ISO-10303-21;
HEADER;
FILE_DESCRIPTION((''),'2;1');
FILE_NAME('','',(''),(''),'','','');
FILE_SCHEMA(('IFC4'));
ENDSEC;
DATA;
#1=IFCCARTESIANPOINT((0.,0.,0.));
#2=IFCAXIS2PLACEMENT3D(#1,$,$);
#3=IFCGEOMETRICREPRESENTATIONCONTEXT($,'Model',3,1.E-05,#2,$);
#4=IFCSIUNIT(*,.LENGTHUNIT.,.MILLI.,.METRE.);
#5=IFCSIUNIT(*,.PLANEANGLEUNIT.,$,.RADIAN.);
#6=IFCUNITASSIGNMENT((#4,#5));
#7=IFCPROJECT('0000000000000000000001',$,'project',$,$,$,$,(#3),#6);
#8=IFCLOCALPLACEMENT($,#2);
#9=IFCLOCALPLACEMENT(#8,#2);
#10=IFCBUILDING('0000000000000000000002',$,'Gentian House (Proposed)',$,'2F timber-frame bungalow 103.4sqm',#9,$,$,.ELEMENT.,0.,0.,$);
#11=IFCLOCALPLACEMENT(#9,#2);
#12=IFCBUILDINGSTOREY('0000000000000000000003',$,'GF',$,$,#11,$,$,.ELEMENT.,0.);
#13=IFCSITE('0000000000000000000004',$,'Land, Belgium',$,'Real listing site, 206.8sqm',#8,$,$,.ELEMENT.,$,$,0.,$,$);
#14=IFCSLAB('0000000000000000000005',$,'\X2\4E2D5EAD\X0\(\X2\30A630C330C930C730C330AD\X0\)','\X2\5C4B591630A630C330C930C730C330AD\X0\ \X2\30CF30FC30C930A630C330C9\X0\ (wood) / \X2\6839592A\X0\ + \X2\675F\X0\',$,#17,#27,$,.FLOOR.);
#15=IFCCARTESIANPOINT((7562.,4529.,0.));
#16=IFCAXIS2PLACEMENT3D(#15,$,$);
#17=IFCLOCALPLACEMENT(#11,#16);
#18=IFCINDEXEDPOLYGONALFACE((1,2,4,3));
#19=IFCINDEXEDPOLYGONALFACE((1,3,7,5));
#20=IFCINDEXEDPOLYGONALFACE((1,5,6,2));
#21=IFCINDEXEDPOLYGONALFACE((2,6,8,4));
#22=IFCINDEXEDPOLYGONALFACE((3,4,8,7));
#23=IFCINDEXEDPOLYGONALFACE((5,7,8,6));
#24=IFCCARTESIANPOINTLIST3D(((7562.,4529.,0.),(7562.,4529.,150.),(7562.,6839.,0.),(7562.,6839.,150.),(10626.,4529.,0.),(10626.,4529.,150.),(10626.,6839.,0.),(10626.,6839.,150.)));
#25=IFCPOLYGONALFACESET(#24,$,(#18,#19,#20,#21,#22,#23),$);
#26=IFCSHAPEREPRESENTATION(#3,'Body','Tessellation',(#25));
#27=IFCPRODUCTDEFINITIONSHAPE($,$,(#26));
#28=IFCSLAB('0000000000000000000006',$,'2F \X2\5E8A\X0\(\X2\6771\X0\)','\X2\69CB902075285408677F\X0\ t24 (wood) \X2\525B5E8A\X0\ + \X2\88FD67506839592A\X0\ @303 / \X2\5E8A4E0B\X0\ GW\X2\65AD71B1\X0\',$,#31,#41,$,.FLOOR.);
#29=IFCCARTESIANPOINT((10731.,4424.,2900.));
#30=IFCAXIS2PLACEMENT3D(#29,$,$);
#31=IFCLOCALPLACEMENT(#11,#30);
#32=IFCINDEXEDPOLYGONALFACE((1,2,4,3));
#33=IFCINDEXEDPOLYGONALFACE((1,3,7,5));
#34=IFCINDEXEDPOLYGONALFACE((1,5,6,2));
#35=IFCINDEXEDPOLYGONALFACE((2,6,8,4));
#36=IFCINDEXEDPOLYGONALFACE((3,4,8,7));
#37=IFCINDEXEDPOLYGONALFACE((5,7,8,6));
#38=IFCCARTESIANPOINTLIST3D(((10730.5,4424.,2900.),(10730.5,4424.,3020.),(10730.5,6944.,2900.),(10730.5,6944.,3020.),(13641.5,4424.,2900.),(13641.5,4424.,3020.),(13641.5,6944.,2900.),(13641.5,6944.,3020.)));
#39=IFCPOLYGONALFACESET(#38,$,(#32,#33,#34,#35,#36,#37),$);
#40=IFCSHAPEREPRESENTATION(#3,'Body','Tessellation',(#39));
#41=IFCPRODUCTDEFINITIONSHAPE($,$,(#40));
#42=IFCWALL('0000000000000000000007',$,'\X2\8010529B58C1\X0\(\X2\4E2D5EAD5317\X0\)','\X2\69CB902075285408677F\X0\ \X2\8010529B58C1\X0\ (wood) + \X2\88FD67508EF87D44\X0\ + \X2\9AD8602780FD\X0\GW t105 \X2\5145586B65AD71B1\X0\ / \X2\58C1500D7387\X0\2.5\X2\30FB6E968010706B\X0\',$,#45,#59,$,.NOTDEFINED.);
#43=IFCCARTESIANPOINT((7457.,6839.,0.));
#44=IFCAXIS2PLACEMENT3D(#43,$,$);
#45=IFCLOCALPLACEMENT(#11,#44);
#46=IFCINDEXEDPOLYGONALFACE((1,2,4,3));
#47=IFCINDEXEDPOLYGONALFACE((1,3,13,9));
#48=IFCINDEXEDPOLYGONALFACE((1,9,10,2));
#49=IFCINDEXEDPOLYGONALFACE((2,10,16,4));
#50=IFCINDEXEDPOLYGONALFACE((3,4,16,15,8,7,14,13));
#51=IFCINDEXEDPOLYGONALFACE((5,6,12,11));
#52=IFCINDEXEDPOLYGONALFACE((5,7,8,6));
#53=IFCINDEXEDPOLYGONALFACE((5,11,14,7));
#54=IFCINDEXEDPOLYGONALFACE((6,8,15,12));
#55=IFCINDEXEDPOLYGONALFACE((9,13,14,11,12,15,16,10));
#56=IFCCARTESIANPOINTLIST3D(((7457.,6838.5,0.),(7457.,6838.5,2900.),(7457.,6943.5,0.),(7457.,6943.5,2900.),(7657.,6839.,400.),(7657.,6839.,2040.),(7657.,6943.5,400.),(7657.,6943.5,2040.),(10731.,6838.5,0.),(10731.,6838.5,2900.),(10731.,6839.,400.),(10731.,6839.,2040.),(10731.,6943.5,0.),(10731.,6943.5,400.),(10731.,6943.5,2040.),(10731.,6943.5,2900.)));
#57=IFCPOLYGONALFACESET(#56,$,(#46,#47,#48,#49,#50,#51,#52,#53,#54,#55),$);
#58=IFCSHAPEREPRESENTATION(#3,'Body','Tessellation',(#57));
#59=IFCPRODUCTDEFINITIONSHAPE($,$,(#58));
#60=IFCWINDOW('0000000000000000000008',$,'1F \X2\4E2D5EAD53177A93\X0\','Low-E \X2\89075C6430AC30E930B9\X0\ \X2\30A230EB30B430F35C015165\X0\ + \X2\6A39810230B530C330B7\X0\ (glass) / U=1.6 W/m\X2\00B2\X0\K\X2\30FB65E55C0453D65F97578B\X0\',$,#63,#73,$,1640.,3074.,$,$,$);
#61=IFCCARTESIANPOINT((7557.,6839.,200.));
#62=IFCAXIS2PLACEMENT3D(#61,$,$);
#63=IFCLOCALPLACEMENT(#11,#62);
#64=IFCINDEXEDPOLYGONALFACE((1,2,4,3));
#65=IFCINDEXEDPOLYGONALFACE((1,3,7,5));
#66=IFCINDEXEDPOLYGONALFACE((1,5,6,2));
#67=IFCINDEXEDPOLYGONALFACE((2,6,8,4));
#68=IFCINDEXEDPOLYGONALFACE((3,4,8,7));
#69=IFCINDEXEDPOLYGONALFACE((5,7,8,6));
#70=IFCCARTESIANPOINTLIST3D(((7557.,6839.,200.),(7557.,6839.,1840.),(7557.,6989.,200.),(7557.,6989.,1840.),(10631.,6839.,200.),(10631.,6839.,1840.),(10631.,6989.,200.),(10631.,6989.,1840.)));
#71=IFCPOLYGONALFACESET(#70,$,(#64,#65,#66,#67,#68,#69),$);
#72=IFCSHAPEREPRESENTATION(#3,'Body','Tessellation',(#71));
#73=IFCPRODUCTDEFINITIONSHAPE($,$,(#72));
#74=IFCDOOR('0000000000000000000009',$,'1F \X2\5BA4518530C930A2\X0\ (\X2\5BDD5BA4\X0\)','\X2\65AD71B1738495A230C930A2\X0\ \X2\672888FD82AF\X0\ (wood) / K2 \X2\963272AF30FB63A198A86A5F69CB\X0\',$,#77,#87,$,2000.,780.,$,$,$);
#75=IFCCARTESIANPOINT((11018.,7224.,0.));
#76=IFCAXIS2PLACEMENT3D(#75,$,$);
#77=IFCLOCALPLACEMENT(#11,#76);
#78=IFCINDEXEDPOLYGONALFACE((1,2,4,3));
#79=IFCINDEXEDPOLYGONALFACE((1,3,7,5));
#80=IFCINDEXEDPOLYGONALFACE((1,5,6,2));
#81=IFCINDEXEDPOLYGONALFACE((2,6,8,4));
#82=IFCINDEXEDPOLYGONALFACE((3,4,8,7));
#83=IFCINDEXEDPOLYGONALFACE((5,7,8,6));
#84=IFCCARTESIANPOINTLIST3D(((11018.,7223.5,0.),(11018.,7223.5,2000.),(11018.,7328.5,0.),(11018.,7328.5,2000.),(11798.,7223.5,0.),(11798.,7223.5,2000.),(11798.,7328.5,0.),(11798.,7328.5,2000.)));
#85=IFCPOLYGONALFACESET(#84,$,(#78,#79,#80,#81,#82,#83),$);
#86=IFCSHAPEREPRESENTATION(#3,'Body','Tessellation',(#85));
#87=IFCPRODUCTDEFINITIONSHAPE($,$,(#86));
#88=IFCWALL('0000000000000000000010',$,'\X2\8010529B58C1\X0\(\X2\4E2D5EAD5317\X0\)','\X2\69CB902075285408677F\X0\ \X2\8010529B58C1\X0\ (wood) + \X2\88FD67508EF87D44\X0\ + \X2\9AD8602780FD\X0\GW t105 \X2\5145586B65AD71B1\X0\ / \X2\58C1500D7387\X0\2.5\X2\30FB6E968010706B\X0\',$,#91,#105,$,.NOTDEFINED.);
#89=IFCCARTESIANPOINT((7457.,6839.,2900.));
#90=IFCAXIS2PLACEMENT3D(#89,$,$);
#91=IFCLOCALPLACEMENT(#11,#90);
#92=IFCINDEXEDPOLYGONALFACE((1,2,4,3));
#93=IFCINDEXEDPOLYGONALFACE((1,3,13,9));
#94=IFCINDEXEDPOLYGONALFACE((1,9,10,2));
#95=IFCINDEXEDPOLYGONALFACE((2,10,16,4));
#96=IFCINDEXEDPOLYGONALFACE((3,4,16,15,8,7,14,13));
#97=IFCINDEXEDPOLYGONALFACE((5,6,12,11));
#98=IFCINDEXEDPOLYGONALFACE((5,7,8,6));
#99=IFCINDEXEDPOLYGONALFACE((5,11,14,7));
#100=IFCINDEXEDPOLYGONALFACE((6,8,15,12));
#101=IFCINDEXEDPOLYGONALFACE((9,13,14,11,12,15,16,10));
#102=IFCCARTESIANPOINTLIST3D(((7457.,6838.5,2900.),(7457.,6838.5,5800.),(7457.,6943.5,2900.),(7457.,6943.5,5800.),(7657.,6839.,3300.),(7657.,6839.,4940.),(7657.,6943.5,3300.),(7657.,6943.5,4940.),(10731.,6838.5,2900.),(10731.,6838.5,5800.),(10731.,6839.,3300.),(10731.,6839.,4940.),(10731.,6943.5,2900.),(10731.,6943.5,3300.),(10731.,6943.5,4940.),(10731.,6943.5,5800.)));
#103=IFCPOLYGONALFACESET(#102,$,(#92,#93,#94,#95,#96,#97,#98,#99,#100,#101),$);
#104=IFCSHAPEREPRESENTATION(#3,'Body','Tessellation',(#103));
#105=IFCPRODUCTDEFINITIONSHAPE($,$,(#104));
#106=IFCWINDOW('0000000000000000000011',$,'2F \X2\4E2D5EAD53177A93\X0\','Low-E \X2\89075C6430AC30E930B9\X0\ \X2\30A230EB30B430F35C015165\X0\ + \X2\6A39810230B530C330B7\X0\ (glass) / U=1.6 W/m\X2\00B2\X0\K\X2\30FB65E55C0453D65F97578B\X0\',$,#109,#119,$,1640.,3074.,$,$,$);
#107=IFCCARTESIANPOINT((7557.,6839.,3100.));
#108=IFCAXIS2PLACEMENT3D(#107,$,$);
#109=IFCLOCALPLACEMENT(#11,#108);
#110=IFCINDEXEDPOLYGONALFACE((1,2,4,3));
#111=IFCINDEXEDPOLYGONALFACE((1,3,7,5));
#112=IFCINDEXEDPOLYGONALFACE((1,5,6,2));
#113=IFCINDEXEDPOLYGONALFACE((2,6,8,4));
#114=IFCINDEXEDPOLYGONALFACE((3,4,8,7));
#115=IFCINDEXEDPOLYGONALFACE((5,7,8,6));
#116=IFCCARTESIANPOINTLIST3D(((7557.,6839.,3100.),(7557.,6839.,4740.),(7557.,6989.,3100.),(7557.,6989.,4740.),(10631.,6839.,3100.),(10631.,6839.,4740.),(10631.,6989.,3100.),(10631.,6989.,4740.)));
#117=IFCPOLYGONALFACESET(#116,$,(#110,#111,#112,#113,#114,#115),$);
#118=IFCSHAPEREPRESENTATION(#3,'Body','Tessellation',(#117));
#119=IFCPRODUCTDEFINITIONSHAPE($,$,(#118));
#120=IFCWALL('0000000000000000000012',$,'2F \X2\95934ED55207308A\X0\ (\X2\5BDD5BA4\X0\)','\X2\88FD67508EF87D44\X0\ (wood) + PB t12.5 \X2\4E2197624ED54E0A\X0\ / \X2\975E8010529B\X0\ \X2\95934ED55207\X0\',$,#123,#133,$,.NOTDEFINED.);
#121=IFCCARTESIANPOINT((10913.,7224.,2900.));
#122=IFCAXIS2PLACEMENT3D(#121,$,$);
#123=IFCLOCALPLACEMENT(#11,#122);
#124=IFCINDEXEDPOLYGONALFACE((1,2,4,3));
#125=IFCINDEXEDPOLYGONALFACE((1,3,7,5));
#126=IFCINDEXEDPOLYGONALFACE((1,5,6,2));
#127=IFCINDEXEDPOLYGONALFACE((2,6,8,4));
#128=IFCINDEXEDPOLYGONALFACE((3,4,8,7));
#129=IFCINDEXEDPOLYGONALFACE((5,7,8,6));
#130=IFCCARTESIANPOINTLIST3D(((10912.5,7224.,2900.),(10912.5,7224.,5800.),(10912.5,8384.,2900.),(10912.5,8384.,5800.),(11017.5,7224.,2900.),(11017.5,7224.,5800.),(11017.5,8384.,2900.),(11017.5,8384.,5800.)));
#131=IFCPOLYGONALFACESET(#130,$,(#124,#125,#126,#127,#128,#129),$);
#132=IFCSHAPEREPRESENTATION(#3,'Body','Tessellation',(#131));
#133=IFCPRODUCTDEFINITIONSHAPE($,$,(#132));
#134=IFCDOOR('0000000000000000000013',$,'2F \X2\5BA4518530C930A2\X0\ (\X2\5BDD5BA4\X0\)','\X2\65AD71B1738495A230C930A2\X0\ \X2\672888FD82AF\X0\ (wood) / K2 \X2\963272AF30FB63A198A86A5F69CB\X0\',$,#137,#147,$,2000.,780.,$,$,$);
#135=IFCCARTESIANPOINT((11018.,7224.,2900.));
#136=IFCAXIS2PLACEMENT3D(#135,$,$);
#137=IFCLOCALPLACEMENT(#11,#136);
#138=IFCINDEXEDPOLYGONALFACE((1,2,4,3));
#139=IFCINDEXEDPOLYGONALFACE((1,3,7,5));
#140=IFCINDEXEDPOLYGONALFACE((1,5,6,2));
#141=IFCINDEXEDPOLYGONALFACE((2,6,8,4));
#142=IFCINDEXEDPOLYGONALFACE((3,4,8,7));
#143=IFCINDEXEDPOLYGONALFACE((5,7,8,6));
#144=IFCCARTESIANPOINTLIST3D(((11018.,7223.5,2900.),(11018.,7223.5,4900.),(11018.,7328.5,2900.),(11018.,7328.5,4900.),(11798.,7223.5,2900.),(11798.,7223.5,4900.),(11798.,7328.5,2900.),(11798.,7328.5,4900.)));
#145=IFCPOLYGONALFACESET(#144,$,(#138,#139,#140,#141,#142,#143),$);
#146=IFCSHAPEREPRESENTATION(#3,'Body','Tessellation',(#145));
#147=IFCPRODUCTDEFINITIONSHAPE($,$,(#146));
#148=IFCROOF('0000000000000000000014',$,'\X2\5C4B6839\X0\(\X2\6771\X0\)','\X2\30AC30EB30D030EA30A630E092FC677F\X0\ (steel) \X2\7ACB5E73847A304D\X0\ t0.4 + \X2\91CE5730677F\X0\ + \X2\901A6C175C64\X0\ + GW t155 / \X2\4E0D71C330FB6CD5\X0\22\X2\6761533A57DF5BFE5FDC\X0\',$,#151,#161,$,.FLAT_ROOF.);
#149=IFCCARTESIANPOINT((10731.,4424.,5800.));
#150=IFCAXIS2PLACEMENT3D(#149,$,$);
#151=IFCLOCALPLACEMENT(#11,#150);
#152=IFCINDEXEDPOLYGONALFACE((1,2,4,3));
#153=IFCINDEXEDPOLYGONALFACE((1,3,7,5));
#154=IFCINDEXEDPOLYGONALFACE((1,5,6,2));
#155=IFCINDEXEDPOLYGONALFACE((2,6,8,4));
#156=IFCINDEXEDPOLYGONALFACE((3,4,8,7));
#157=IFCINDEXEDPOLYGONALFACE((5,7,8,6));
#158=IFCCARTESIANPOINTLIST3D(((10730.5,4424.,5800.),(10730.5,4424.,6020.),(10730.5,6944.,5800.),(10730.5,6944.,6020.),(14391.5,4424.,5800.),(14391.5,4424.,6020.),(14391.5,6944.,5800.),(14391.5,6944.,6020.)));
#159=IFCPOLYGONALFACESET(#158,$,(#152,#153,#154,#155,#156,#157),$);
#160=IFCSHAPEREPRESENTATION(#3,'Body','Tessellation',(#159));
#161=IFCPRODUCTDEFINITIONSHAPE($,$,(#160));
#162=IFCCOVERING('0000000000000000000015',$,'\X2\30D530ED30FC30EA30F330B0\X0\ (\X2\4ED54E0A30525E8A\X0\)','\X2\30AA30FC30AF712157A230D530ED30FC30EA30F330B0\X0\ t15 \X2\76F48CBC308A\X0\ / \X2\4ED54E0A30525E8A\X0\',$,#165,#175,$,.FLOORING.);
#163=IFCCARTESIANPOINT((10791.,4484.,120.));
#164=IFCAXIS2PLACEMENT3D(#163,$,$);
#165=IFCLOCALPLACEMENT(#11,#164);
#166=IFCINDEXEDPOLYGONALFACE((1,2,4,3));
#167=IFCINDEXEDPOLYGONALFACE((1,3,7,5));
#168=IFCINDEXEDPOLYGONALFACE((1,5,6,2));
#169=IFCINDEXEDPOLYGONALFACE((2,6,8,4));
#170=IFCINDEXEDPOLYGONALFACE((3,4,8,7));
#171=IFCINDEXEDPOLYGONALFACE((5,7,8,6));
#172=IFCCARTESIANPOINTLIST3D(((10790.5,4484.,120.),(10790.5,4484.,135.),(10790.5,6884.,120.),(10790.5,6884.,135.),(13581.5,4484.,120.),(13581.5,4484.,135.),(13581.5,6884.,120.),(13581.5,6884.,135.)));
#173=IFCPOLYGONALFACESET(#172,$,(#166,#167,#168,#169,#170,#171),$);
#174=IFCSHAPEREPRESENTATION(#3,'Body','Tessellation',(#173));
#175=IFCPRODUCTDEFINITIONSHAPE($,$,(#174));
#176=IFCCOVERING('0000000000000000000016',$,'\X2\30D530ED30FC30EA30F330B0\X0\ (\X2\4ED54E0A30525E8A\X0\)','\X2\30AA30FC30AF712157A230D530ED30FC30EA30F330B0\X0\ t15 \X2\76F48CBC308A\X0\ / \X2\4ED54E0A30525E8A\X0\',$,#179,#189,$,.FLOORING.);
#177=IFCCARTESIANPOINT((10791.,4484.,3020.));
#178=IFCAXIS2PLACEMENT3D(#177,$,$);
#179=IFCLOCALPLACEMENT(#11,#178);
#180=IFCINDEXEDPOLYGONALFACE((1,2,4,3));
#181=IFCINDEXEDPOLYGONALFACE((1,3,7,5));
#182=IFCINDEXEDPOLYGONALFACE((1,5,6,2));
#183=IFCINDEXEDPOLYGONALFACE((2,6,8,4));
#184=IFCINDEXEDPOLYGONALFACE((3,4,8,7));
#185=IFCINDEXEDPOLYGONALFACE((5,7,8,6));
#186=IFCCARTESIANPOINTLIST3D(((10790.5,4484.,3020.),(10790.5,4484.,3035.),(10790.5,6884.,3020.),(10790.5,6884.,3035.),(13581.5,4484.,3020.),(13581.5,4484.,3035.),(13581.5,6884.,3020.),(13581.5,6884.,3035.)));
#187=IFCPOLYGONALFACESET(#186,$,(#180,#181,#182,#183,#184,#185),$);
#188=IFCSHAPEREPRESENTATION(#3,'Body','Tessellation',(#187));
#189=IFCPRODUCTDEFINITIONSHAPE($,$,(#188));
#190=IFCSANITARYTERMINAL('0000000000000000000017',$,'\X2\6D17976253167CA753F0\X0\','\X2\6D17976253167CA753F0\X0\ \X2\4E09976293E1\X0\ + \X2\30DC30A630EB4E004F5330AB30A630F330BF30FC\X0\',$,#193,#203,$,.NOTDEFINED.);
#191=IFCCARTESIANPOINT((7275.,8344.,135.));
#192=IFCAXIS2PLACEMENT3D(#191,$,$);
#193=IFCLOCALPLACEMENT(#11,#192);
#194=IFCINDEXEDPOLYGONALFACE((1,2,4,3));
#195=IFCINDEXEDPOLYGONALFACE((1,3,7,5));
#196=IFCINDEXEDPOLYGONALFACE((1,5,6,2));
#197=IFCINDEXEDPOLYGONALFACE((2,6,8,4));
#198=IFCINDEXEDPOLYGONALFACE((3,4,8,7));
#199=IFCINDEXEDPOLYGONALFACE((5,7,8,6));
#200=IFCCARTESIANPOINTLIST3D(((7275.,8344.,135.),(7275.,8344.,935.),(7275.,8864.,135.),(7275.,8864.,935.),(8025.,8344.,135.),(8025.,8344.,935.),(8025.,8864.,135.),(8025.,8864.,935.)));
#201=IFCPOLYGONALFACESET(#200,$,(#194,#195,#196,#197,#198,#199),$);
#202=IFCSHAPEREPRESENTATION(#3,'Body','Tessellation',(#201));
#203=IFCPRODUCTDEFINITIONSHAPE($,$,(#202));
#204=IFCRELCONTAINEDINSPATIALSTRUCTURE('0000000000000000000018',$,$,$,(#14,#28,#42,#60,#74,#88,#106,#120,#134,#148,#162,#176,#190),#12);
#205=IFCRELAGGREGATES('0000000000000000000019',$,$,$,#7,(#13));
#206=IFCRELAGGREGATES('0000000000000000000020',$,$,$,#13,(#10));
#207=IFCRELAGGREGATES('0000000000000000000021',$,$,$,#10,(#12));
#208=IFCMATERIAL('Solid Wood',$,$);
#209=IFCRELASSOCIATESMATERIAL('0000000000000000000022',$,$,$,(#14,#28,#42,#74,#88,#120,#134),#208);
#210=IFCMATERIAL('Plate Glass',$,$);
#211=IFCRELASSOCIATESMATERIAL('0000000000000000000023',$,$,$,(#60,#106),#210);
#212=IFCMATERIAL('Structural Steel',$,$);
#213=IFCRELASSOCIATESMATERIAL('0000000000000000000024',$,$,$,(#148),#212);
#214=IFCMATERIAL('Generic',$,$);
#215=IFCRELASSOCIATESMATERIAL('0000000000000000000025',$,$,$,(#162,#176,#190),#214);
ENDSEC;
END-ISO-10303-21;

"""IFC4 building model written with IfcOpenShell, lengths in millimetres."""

from ifc_helpers import new_model, si_unit, frame, frame_2d, origin, place, context, project, spatial, rectangle, extrude, material, element, fill, save


model = new_model("IFC4")

# Units and contexts
model_context = context("Model", 3, precision=1e-05, world=origin())
ifc_project = project(units=[si_unit("LENGTHUNIT", "METRE", prefix="MILLI"), si_unit("PLANEANGLEUNIT", "RADIAN")], contexts=[model_context])

# Site, building, storey
site_placement = place(None, origin())
site = spatial("IfcSite", under=ifc_project, at=site_placement, Name="Land, Belgium", ObjectType="Real listing site, 206.8sqm", CompositionType="ELEMENT", RefElevation=0.0)
building_placement = place(site_placement, origin())
building = spatial("IfcBuilding", under=site, at=building_placement, Name="Gentian House (Proposed)", ObjectType="2F timber-frame bungalow 103.4sqm", CompositionType="ELEMENT", ElevationOfRefHeight=0.0, ElevationOfTerrain=0.0)
storey_placement = place(building_placement, origin())
storey = spatial("IfcBuildingStorey", under=building, at=storey_placement, Name="GF", CompositionType="ELEMENT", Elevation=0.0)

# Slabs
ifc_material_1 = material(Name="Solid Wood")
slab_1_placement = place(storey_placement, frame((7562.0, 4529.0, 0.0)))
element("IfcSlab", 1, at=slab_1_placement, inside=storey, material=ifc_material_1, Name="中庭(ウッドデッキ)", Description="屋外ウッドデッキ ハードウッド (wood) / 根太 + 束", PredefinedType="FLOOR", context=model_context, shape_type="SweptSolid", body=[
    extrude(rectangle(XDim=3064.0, YDim=2310.0, at=frame_2d((1532.0, 1155.0))), frame((7562.0, 4529.0, 0.0)), (0.0, 0.0, 1.0), 150.0),
])
slab_2_placement = place(storey_placement, frame((10731.0, 4424.0, 2900.0)))
element("IfcSlab", 2, at=slab_2_placement, inside=storey, material=ifc_material_1, Name="2F 床(東)", Description="構造用合板 t24 (wood) 剛床 + 製材根太 @303 / 床下 GW断熱", PredefinedType="FLOOR", context=model_context, shape_type="SweptSolid", body=[
    extrude(rectangle(XDim=2911.0, YDim=2520.0, at=frame_2d((1455.0, 1260.0))), frame((10731.0, 4424.0, 2900.0)), (0.0, 0.0, 1.0), 120.0),
])

# Wall, opening, window
wall_1_placement = place(storey_placement, frame((7457.0, 6839.0, 0.0)))
wall_1 = element("IfcWall", 3, at=wall_1_placement, inside=storey, material=ifc_material_1, Name="耐力壁(中庭北)", Description="構造用合板 耐力壁 (wood) + 製材軸組 + 高性能GW t105 充填断熱 / 壁倍率2.5・準耐火", PredefinedType="NOTDEFINED", context=model_context, shape_type="SweptSolid", body=[
    extrude(rectangle(XDim=3274.0, YDim=105.0, at=frame_2d((1637.0, 52.0))), frame((7457.0, 6839.0, 0.0)), (0.0, 0.0, 1.0), 2900.0),
])
opening_1_placement = place(storey_placement, frame((7557.0, 6839.0, 200.0)))
opening_1 = element("IfcOpeningElement", 4, at=opening_1_placement, cuts=wall_1, PredefinedType="NOTDEFINED", context=model_context, shape_type="SweptSolid", body=[
    extrude(rectangle(XDim=3074.0, YDim=150.0, at=frame_2d((1537.0, 75.0))), frame((7557.0, 6839.0, 200.0)), (0.0, 0.0, 1.0), 1640.0),
])
ifc_material_2 = material(Name="Plate Glass")
window_1_placement = place(storey_placement, frame((7557.0, 6839.0, 200.0)))
window_1 = element("IfcWindow", 5, at=window_1_placement, inside=storey, material=ifc_material_2, Name="1F 中庭北窓", Description="Low-E 複層ガラス アルゴン封入 + 樹脂サッシ (glass) / U=1.6 W/m²K・日射取得型", OverallHeight=1640.0, OverallWidth=3074.0, context=model_context, shape_type="SweptSolid", body=[
    extrude(rectangle(XDim=3074.0, YDim=150.0, at=frame_2d((1537.0, 75.0))), frame((7557.0, 6839.0, 200.0)), (0.0, 0.0, 1.0), 1640.0),
])
fill(opening_1, window_1)

# Door
door_1_placement = place(storey_placement, frame((11018.0, 7224.0, 0.0)))
element("IfcDoor", 6, at=door_1_placement, inside=storey, material=ifc_material_1, Name="1F 室内ドア (寝室)", Description="断熱玄関ドア 木製芯 (wood) / K2 防犯・採風機構", OverallHeight=2000.0, OverallWidth=780.0, context=model_context, shape_type="SweptSolid", body=[
    extrude(rectangle(XDim=780.0, YDim=105.0, at=frame_2d((390.0, 52.0))), frame((11018.0, 7224.0, 0.0)), (0.0, 0.0, 1.0), 2000.0),
])

# Wall, opening, window
wall_2_placement = place(storey_placement, frame((7457.0, 6839.0, 2900.0)))
wall_2 = element("IfcWall", 7, at=wall_2_placement, inside=storey, material=ifc_material_1, Name="耐力壁(中庭北)", Description="構造用合板 耐力壁 (wood) + 製材軸組 + 高性能GW t105 充填断熱 / 壁倍率2.5・準耐火", PredefinedType="NOTDEFINED", context=model_context, shape_type="SweptSolid", body=[
    extrude(rectangle(XDim=3274.0, YDim=105.0, at=frame_2d((1637.0, 52.0))), frame((7457.0, 6839.0, 2900.0)), (0.0, 0.0, 1.0), 2900.0),
])
opening_2_placement = place(storey_placement, frame((7557.0, 6839.0, 3100.0)))
opening_2 = element("IfcOpeningElement", 8, at=opening_2_placement, cuts=wall_2, PredefinedType="NOTDEFINED", context=model_context, shape_type="SweptSolid", body=[
    extrude(rectangle(XDim=3074.0, YDim=150.0, at=frame_2d((1537.0, 75.0))), frame((7557.0, 6839.0, 3100.0)), (0.0, 0.0, 1.0), 1640.0),
])
window_2_placement = place(storey_placement, frame((7557.0, 6839.0, 3100.0)))
window_2 = element("IfcWindow", 9, at=window_2_placement, inside=storey, material=ifc_material_2, Name="2F 中庭北窓", Description="Low-E 複層ガラス アルゴン封入 + 樹脂サッシ (glass) / U=1.6 W/m²K・日射取得型", OverallHeight=1640.0, OverallWidth=3074.0, context=model_context, shape_type="SweptSolid", body=[
    extrude(rectangle(XDim=3074.0, YDim=150.0, at=frame_2d((1537.0, 75.0))), frame((7557.0, 6839.0, 3100.0)), (0.0, 0.0, 1.0), 1640.0),
])
fill(opening_2, window_2)

# Wall
wall_3_placement = place(storey_placement, frame((10913.0, 7224.0, 2900.0)))
element("IfcWall", 10, at=wall_3_placement, inside=storey, material=ifc_material_1, Name="2F 間仕切り (寝室)", Description="製材軸組 (wood) + PB t12.5 両面仕上 / 非耐力 間仕切", PredefinedType="NOTDEFINED", context=model_context, shape_type="SweptSolid", body=[
    extrude(rectangle(XDim=105.0, YDim=1160.0, at=frame_2d((52.0, 580.0))), frame((10913.0, 7224.0, 2900.0)), (0.0, 0.0, 1.0), 2900.0),
])

# Door
door_2_placement = place(storey_placement, frame((11018.0, 7224.0, 2900.0)))
element("IfcDoor", 11, at=door_2_placement, inside=storey, material=ifc_material_1, Name="2F 室内ドア (寝室)", Description="断熱玄関ドア 木製芯 (wood) / K2 防犯・採風機構", OverallHeight=2000.0, OverallWidth=780.0, context=model_context, shape_type="SweptSolid", body=[
    extrude(rectangle(XDim=780.0, YDim=105.0, at=frame_2d((390.0, 52.0))), frame((11018.0, 7224.0, 2900.0)), (0.0, 0.0, 1.0), 2000.0),
])

# Roof
ifc_material_3 = material(Name="Structural Steel")
for number, where, name in (
    (12, (10731.0, 4424.0, 5800.0), "屋根(東)"),
):
    element("IfcRoof", number, at=place(storey_placement, frame(where)), inside=storey, material=ifc_material_3, Name=name, Description="ガルバリウム鋼板 (steel) 立平葺き t0.4 + 野地板 + 通気層 + GW t155 / 不燃・法22条区域対応", PredefinedType="FLAT_ROOF", context=model_context, shape_type="SweptSolid", body=[
        extrude(rectangle(XDim=3661.0, YDim=2520.0, at=frame_2d((1830.0, 1260.0))), frame((10731.0, 4424.0, 5800.0)), (0.0, 0.0, 1.0), 220.0),
    ])

# Coverings
ifc_material_4 = material(Name="Generic")
covering_1_placement = place(storey_placement, frame((10791.0, 4484.0, 120.0)))
element("IfcCovering", 13, at=covering_1_placement, inside=storey, material=ifc_material_4, Name="フローリング (仕上げ床)", Description="オーク無垢フローリング t15 直貼り / 仕上げ床", PredefinedType="FLOORING", context=model_context, shape_type="SweptSolid", body=[
    extrude(rectangle(XDim=2791.0, YDim=2400.0, at=frame_2d((1395.0, 1200.0))), frame((10791.0, 4484.0, 120.0)), (0.0, 0.0, 1.0), 15.0),
])
covering_2_placement = place(storey_placement, frame((10791.0, 4484.0, 3020.0)))
element("IfcCovering", 14, at=covering_2_placement, inside=storey, material=ifc_material_4, Name="フローリング (仕上げ床)", Description="オーク無垢フローリング t15 直貼り / 仕上げ床", PredefinedType="FLOORING", context=model_context, shape_type="SweptSolid", body=[
    extrude(rectangle(XDim=2791.0, YDim=2400.0, at=frame_2d((1395.0, 1200.0))), frame((10791.0, 4484.0, 3020.0)), (0.0, 0.0, 1.0), 15.0),
])

# Sanitary terminal
sanitary_terminal_1_placement = place(storey_placement, frame((7275.0, 8344.0, 135.0)))
element("IfcSanitaryTerminal", 15, at=sanitary_terminal_1_placement, inside=storey, material=ifc_material_4, Name="洗面化粧台", Description="洗面化粧台 三面鏡 + ボウル一体カウンター", PredefinedType="NOTDEFINED", context=model_context, shape_type="SweptSolid", body=[
    extrude(rectangle(XDim=750.0, YDim=520.0, at=frame_2d((375.0, 260.0))), frame((7275.0, 8344.0, 135.0)), (0.0, 0.0, 1.0), 800.0),
])

save(model, "model.ifc")
